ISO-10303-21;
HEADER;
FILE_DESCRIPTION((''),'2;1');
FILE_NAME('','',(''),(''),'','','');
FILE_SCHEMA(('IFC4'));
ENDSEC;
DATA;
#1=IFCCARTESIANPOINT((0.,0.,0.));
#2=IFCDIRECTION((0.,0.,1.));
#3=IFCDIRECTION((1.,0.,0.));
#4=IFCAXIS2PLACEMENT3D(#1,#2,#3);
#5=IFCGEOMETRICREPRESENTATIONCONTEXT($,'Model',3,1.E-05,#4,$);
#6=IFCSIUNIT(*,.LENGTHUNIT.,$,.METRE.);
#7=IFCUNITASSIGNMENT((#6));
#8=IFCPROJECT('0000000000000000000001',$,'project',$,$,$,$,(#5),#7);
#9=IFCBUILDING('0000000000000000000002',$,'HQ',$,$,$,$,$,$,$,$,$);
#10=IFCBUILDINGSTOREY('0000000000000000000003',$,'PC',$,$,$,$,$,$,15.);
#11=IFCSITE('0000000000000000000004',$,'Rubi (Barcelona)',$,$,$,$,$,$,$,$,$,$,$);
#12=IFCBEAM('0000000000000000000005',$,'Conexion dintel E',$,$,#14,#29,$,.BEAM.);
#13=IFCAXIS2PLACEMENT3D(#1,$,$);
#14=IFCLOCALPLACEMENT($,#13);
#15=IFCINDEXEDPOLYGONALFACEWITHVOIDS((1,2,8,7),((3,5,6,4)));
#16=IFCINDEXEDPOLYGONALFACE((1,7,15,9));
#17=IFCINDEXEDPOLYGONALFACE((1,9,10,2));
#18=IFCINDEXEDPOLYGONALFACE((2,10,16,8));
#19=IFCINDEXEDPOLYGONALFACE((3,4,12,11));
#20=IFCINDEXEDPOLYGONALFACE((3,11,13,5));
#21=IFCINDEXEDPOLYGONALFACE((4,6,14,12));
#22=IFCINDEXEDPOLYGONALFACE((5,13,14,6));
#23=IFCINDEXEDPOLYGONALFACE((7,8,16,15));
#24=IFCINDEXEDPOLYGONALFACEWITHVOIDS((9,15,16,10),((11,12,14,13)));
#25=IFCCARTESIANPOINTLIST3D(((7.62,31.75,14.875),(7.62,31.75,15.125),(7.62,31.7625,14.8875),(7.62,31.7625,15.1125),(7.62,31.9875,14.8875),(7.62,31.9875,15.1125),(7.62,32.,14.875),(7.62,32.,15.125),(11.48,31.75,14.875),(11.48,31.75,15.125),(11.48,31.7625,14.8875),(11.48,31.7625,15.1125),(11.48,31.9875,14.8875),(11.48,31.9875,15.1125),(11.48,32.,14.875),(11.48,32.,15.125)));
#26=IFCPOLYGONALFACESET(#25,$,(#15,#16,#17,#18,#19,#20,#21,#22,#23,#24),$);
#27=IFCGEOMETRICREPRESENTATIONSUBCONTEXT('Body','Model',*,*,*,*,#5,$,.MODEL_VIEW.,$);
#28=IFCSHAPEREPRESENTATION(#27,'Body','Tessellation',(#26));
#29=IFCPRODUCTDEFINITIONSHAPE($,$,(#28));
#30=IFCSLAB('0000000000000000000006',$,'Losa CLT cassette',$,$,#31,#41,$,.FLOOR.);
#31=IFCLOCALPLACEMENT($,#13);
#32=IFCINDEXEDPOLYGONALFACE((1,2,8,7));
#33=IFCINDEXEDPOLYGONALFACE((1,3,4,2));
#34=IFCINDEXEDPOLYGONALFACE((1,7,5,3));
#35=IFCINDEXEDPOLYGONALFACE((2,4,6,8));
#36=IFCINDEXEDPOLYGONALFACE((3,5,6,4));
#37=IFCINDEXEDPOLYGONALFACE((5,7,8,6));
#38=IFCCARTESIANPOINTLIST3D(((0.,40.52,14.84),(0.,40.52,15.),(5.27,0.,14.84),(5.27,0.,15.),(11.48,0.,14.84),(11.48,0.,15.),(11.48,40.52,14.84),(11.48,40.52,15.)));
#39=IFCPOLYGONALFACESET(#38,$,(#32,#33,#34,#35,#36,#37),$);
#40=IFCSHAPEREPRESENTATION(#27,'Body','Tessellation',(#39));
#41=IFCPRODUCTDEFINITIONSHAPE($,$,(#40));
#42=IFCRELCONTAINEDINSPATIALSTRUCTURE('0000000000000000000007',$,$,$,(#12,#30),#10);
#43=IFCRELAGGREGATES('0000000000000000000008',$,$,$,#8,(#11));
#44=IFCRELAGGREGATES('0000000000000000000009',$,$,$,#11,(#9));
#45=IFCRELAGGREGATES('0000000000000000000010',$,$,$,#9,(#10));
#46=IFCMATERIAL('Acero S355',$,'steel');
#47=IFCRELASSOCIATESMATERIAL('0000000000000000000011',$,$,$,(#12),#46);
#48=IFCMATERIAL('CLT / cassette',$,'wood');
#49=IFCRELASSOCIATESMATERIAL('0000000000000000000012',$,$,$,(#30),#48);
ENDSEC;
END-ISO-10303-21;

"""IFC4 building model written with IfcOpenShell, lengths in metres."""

from ifc_helpers import new_model, si_unit, frame, origin_with_axes, place, context, subcontext, project, spatial, polyline, hollow_rectangle, outline, extrude, material, element, save


model = new_model("IFC4")

# Units and contexts
model_context = context("Model", 3, precision=1e-05, world=origin_with_axes())
body_context = subcontext(model_context, "Body", "Model", "MODEL_VIEW")
ifc_project = project(units=[si_unit("LENGTHUNIT", "METRE")], contexts=[model_context])

# Site, building, storey
site = spatial("IfcSite", under=ifc_project, Name="Rubi (Barcelona)")
building = spatial("IfcBuilding", under=site, Name="HQ")
storey = spatial("IfcBuildingStorey", under=building, Name="PC", Elevation=15.0)

# Beam
ifc_material_1 = material(Name="Acero S355", Category="steel")
beam_1_placement = place(None, origin_with_axes())
element("IfcBeam", 1, at=beam_1_placement, inside=storey, material=ifc_material_1, Name="Conexion dintel E", PredefinedType="BEAM", context=body_context, shape_type="SweptSolid", body=[
    extrude(hollow_rectangle(XDim=0.25, YDim=0.25, WallThickness=0.0125), frame((7.62, 31.875, 15.0), z_axis=(1.0, 0.0, 0.0), x_axis=(0.0, 1.0, 0.0)), (0.0, 0.0, 1.0), 3.86),
])

# Slab
ifc_material_2 = material(Name="CLT / cassette", Category="wood")
slab_placement = place(None, origin_with_axes())
element("IfcSlab", 2, at=slab_placement, inside=storey, material=ifc_material_2, Name="Losa CLT cassette", PredefinedType="FLOOR", context=body_context, shape_type="SweptSolid", body=[
    extrude(outline(polyline([(5.27, 0.0, 0.0), (11.48, 0.0, 0.0), (11.48, 40.52, 0.0), (0.0, 40.52, 0.0), (5.27, 0.0, 0.0)])), frame((0.0, 0.0, 14.84)), (0.0, 0.0, 1.0), 0.16),
])

save(model, "model.ifc")
